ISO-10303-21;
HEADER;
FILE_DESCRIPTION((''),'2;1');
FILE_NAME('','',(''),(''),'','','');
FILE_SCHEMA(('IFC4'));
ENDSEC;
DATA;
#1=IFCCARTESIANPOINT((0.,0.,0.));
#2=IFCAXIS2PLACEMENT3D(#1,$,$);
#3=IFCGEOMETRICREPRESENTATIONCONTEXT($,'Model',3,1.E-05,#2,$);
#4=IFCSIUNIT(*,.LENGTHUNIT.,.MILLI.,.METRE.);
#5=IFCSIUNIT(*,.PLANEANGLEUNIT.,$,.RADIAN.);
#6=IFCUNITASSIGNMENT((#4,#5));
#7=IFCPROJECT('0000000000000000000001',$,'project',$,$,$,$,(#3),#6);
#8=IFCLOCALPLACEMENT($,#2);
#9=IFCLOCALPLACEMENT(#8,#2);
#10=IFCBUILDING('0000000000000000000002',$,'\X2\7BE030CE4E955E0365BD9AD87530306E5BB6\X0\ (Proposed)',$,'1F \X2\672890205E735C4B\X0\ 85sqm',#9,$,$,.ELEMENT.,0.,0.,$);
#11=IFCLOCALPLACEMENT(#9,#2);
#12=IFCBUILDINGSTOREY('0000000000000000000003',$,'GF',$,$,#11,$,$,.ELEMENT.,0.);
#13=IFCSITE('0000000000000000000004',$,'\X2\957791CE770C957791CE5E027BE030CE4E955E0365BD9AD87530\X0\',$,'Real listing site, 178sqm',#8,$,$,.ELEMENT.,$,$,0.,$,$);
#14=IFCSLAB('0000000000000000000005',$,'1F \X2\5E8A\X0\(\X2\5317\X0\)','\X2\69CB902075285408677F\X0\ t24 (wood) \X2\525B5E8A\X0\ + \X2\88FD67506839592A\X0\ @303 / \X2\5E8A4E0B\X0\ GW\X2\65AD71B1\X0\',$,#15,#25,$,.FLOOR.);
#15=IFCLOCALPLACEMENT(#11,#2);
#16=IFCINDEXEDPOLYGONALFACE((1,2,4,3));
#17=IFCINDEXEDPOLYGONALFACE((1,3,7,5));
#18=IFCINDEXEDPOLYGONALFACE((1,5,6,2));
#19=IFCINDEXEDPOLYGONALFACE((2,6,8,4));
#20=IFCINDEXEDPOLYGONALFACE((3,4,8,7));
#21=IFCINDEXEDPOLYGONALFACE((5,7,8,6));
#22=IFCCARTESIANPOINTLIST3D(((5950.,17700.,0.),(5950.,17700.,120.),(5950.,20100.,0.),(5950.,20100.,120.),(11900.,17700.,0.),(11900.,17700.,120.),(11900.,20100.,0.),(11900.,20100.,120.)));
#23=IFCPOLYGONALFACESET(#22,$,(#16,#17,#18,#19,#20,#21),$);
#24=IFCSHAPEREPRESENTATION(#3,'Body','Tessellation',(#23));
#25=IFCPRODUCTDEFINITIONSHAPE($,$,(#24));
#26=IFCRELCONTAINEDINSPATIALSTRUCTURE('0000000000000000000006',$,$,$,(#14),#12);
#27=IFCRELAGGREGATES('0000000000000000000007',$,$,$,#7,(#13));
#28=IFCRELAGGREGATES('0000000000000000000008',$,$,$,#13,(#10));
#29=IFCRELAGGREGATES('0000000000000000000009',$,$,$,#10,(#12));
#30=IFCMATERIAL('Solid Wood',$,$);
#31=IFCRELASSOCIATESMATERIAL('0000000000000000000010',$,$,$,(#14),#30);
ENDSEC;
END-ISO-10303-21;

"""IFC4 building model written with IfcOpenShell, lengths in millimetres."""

from ifc_helpers import new_model, si_unit, frame, frame_2d, origin, place, context, project, spatial, rectangle, extrude, material, element, save


model = new_model("IFC4")

# Units and contexts
model_context = context("Model", 3, precision=1e-05, world=origin())
ifc_project = project(units=[si_unit("LENGTHUNIT", "METRE", prefix="MILLI"), si_unit("PLANEANGLEUNIT", "RADIAN")], contexts=[model_context])

# Site, building, storey
site_placement = place(None, origin())
site = spatial("IfcSite", under=ifc_project, at=site_placement, Name="長野県長野市篠ノ井布施高田", ObjectType="Real listing site, 178sqm", CompositionType="ELEMENT", RefElevation=0.0)
building_placement = place(site_placement, origin())
building = spatial("IfcBuilding", under=site, at=building_placement, Name="篠ノ井布施高田の家 (Proposed)", ObjectType="1F 木造平屋 85sqm", CompositionType="ELEMENT", ElevationOfRefHeight=0.0, ElevationOfTerrain=0.0)
storey_placement = place(building_placement, origin())
storey = spatial("IfcBuildingStorey", under=building, at=storey_placement, Name="GF", CompositionType="ELEMENT", Elevation=0.0)

# Slab
ifc_material_1 = material(Name="Solid Wood")
slab_1_placement = place(storey_placement, frame((2975.0, 8850.0, 0.0)))
element("IfcSlab", 1, at=slab_1_placement, inside=storey, material=ifc_material_1, Name="1F 床(北)", Description="構造用合板 t24 (wood) 剛床 + 製材根太 @303 / 床下 GW断熱", PredefinedType="FLOOR", context=model_context, shape_type="SweptSolid", body=[
    extrude(rectangle(XDim=5950.0, YDim=2400.0, at=frame_2d((2975.0, 1200.0))), frame((2975.0, 8850.0, 0.0)), (0.0, 0.0, 1.0), 120.0),
])

save(model, "model.ifc")
